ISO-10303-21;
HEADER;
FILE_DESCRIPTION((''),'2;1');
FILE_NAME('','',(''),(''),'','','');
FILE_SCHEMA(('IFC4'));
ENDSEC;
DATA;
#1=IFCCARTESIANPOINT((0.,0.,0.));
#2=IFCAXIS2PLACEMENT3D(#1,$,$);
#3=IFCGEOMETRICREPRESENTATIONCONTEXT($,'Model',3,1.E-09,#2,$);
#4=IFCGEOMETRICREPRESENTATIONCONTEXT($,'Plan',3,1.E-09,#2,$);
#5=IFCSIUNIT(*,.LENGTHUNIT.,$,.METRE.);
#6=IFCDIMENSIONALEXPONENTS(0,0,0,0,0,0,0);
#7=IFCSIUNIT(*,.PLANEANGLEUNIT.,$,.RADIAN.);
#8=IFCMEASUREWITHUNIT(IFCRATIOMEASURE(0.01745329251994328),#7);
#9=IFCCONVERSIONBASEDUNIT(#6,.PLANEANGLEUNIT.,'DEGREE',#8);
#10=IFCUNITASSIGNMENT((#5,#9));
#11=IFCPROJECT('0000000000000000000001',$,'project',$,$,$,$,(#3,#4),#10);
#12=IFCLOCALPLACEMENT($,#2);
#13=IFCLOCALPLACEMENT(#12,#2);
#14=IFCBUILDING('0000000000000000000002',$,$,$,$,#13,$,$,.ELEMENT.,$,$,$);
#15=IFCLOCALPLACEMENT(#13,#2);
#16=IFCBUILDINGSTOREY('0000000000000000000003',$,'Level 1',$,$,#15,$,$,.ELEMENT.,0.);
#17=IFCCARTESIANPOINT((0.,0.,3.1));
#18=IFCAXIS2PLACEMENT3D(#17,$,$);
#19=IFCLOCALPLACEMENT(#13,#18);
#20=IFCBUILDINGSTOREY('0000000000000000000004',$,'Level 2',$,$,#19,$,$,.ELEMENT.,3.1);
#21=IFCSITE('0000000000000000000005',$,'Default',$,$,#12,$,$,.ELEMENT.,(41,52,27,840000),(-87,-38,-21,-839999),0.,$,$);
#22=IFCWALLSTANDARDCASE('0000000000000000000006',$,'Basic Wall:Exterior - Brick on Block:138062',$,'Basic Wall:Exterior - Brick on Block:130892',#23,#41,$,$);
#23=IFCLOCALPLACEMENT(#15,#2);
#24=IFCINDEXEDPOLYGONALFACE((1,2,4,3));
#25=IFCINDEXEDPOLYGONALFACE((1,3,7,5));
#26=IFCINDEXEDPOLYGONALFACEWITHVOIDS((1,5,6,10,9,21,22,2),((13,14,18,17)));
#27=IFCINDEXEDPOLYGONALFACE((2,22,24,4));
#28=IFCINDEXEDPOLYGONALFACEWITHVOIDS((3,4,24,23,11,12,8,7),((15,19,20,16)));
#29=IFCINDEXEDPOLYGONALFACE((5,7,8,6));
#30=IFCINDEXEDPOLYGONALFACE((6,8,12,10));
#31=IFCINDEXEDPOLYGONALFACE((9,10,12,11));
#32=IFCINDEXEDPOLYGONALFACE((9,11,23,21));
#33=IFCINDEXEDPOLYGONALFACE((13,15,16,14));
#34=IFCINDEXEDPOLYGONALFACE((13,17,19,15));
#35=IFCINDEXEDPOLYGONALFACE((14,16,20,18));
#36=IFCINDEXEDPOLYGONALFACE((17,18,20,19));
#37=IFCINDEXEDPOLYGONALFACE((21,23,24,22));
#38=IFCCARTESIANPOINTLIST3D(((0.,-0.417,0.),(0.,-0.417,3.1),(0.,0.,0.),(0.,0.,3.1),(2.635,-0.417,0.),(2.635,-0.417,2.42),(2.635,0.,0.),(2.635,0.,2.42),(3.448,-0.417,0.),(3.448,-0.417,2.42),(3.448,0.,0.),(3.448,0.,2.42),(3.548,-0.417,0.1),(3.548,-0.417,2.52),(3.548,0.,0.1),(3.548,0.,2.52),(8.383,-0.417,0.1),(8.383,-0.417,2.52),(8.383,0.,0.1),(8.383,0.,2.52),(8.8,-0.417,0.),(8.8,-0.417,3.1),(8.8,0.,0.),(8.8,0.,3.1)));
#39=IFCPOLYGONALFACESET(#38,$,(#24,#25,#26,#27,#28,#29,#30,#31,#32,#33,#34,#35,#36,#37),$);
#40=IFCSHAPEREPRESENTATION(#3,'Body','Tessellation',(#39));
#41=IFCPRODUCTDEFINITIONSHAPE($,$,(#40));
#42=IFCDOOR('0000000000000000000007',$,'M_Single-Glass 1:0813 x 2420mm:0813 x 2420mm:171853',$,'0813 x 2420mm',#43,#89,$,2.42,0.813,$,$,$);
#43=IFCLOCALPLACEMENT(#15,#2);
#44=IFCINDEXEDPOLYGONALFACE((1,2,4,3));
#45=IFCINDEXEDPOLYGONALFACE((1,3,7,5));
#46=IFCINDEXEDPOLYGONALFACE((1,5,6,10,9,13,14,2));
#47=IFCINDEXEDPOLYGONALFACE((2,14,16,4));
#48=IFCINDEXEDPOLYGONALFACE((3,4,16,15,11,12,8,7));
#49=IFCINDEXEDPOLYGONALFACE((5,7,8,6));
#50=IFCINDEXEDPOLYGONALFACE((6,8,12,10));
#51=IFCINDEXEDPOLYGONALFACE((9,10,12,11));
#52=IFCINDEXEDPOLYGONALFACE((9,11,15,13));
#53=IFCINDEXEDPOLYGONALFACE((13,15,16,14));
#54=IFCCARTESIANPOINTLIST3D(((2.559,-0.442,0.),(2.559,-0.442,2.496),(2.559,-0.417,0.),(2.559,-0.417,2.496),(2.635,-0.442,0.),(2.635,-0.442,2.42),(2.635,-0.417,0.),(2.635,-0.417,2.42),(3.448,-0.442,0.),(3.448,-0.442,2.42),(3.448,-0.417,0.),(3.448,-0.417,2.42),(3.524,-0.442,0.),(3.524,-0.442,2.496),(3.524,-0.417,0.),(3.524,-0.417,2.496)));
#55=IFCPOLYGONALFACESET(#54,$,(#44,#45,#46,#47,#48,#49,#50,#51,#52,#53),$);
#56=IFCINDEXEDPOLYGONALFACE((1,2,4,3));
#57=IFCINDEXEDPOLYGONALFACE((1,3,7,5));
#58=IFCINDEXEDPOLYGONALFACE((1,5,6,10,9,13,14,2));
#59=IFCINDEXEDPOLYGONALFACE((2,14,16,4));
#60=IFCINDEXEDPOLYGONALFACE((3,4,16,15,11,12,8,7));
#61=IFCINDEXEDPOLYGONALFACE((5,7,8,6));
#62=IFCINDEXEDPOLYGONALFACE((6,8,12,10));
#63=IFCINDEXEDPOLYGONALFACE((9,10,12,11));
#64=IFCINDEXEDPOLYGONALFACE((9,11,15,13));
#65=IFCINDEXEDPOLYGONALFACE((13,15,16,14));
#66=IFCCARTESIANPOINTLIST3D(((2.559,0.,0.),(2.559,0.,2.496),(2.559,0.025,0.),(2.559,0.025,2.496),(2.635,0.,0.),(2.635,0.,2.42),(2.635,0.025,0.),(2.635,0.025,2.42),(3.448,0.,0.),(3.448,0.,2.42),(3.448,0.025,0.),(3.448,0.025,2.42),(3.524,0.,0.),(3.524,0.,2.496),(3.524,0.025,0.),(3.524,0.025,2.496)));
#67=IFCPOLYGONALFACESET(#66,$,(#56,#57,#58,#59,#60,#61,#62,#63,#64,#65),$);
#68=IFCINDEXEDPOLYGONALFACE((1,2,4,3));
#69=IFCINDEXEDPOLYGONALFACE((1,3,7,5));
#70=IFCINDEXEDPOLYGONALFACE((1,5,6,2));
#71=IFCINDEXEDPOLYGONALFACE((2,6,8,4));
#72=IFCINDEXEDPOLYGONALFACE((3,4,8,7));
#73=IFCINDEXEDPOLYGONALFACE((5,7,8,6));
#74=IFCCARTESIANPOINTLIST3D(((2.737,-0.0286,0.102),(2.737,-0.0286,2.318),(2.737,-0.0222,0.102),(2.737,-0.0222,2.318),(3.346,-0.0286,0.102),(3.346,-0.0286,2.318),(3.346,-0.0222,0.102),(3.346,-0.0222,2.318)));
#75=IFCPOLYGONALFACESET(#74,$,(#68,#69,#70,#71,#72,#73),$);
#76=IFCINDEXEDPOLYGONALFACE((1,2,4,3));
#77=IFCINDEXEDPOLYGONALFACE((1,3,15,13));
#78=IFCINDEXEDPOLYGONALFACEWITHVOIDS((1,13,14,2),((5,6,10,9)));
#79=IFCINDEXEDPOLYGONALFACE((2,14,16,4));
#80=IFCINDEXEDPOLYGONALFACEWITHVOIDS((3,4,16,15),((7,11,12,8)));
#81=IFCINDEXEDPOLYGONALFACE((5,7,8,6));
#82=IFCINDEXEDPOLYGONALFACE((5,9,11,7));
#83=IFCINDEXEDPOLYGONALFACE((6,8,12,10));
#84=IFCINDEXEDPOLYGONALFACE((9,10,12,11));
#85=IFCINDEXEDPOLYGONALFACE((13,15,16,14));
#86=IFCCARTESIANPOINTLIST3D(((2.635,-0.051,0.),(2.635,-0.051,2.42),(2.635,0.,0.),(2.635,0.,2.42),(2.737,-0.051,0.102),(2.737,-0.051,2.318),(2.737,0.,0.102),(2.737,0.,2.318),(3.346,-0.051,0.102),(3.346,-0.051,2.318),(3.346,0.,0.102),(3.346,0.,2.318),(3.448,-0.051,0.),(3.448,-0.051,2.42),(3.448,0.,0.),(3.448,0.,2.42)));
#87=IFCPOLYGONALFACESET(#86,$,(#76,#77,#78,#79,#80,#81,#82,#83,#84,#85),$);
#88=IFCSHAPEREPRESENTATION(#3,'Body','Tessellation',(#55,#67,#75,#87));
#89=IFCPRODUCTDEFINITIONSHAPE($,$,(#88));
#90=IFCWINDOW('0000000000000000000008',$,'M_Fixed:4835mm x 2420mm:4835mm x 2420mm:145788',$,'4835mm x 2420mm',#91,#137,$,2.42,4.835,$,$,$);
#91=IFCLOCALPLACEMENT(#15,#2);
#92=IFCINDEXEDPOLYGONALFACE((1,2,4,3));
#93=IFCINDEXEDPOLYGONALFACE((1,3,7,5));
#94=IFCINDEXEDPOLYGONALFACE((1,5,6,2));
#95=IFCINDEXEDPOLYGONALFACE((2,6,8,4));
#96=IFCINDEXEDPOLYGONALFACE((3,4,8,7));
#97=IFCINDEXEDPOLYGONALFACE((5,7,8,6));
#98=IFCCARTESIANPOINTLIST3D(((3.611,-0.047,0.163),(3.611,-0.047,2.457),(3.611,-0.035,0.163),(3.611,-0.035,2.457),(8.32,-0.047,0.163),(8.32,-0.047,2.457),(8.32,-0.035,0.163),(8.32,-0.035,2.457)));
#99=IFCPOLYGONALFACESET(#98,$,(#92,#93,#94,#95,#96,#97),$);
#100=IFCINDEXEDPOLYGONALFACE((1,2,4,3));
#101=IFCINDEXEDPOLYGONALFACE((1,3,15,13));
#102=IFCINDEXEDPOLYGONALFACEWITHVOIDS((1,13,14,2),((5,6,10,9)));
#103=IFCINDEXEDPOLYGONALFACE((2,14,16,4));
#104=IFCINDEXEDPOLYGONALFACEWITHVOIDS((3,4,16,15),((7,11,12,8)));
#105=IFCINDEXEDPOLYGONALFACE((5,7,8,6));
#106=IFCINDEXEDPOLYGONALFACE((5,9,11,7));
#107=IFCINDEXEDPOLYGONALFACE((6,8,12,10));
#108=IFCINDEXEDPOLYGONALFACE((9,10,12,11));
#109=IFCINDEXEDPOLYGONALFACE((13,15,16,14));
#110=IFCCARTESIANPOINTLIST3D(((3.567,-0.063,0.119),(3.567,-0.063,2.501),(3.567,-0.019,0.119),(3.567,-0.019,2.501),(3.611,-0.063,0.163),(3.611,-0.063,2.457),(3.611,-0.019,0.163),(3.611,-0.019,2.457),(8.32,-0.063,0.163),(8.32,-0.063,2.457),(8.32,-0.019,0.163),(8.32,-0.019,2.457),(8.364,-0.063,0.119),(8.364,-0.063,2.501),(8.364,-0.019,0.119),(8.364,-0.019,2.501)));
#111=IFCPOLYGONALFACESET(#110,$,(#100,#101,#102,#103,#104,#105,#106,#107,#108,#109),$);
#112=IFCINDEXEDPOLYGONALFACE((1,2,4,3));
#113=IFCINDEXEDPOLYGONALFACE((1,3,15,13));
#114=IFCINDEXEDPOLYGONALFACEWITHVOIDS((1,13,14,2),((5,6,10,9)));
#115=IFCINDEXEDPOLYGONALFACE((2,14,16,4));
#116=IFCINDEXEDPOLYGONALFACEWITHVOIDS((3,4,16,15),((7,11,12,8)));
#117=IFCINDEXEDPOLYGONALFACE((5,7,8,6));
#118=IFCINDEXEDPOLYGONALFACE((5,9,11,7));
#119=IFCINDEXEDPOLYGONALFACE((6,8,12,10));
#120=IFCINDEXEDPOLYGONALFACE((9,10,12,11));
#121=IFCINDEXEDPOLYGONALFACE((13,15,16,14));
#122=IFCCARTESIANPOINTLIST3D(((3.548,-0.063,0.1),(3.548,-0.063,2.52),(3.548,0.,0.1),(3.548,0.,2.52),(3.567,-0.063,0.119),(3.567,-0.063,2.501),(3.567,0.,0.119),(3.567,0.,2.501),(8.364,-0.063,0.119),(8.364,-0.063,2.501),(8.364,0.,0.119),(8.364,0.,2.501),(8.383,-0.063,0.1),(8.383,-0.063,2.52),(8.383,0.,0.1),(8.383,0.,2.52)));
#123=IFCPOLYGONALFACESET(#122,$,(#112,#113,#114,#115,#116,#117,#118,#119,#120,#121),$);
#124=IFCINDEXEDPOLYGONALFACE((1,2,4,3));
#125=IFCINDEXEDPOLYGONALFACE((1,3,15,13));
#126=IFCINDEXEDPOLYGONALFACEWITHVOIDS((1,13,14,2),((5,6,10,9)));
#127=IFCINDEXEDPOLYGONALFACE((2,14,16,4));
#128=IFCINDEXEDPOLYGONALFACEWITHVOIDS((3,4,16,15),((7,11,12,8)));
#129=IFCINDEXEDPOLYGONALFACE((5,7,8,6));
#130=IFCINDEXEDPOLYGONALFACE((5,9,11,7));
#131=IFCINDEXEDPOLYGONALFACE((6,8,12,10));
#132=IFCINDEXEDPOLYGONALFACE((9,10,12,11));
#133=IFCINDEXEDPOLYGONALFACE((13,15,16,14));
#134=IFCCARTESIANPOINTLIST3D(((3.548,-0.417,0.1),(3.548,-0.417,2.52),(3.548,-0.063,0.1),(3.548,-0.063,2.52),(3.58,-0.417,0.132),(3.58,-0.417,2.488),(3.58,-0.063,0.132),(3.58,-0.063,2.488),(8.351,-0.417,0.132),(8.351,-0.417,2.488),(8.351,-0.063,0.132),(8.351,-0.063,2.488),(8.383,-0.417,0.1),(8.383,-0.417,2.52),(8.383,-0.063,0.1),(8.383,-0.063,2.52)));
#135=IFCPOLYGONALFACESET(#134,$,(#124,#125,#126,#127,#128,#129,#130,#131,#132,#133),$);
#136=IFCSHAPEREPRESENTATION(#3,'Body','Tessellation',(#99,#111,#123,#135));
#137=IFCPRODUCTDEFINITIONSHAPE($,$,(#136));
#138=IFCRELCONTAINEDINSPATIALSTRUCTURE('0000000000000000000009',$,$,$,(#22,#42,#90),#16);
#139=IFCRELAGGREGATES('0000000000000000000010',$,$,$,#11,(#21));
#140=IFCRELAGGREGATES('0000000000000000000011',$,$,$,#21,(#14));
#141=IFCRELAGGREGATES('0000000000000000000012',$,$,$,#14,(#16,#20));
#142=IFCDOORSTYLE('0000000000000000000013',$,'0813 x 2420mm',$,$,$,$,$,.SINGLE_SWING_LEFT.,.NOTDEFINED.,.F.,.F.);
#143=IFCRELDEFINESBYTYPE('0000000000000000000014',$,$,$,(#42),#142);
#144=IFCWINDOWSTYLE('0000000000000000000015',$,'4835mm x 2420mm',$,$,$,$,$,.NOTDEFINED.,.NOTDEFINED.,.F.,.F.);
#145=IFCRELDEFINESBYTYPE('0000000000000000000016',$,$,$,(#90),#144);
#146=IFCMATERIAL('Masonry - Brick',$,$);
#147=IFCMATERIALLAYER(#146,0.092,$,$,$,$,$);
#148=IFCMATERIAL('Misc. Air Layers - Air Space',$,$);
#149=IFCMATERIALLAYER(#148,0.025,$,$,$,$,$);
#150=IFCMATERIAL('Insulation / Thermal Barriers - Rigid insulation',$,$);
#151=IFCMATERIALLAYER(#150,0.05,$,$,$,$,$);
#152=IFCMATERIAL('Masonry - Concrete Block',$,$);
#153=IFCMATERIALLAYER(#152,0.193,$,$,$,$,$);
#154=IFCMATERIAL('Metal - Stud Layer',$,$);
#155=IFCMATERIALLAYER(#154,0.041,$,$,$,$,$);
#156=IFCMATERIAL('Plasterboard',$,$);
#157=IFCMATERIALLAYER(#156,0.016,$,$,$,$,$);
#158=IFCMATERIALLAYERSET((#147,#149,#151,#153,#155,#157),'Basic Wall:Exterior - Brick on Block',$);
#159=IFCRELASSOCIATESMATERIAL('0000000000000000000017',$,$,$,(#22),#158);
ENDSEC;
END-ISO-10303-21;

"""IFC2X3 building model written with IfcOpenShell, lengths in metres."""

from ifc_helpers import new_model, entity, si_unit, converted_unit, frame, frame_2d, origin, origin_2d_with_axis, place, context, project, spatial, polyline, rectangle, outline, extrude, source, transform, mapped, material, layer, layer_set, layer_usage, type_object, type_shapes, element, fill, save


model = new_model("IFC2X3")

# Units and contexts
model_context = context("Model", 3, precision=1e-09, world=origin())
plan_context = context("Plan", 3, precision=1e-09, world=origin())
ifc_project = project(units=[si_unit("LENGTHUNIT", "METRE"), converted_unit("PLANEANGLEUNIT", "DEGREE", entity("IfcRatioMeasure", 0.01745329251994328), si_unit("PLANEANGLEUNIT", "RADIAN"), dimensions=[0, 0, 0, 0, 0, 0, 0])], contexts=[model_context, plan_context])

# Site, building, storey
site_placement = place(None, origin())
site = spatial("IfcSite", under=ifc_project, at=site_placement, Name="Default", CompositionType="ELEMENT", RefLatitude=(41, 52, 27, 840000), RefLongitude=(-87, -38, -21, -839999), RefElevation=0.0)
building_placement = place(site_placement, origin())
building = spatial("IfcBuilding", under=site, at=building_placement, CompositionType="ELEMENT")
storey_1_placement = place(building_placement, origin())
storey_1 = spatial("IfcBuildingStorey", under=building, at=storey_1_placement, Name="Level 1", CompositionType="ELEMENT", Elevation=0.0)

# Shared definitions
ifc_material_1 = material(Name="Masonry - Brick")
ifc_layer_1 = layer(ifc_material_1, 0.092)
ifc_material_2 = material(Name="Misc. Air Layers - Air Space")
ifc_layer_2 = layer(ifc_material_2, 0.025)
ifc_material_3 = material(Name="Insulation / Thermal Barriers - Rigid insulation")
ifc_layer_3 = layer(ifc_material_3, 0.05)
ifc_material_4 = material(Name="Masonry - Concrete Block")
ifc_layer_4 = layer(ifc_material_4, 0.193)
ifc_material_5 = material(Name="Metal - Stud Layer")
ifc_layer_5 = layer(ifc_material_5, 0.041)
ifc_material_6 = material(Name="Plasterboard")
ifc_layer_6 = layer(ifc_material_6, 0.016)
ifc_layer_set_1 = layer_set([ifc_layer_1, ifc_layer_2, ifc_layer_3, ifc_layer_4, ifc_layer_5, ifc_layer_6], Name="Basic Wall:Exterior - Brick on Block")
ifc_layer_usage_1 = layer_usage(ifc_layer_set_1, "AXIS2", "NEGATIVE", 0.2085)

# Wall, openings, door, window
wall_1_placement = place(storey_1_placement, frame((0.0, -0.2085, 0.0)))
wall_1 = element("IfcWallStandardCase", 1, at=wall_1_placement, inside=storey_1, material=ifc_layer_usage_1, Name="Basic Wall:Exterior - Brick on Block:138062", ObjectType="Basic Wall:Exterior - Brick on Block:130892", context=model_context, shape_type="SweptSolid", body=[
    extrude(rectangle(XDim=8.8, YDim=0.417, at=frame_2d((4.4, 0.0), x_axis=(-1.0, 0.0))), origin(), (0.0, 0.0, 1.0), 3.1),
])
opening_1_placement = place(wall_1_placement, frame((3.548, -0.2085, 0.1)))
opening_1 = element("IfcOpeningElement", 2, at=opening_1_placement, cuts=wall_1, ObjectType="Opening", context=model_context, shape_type="SweptSolid", body=[
    extrude(rectangle(XDim=2.42, YDim=4.835, at=frame_2d((1.21, 2.4175), x_axis=(1.0, 0.0))), frame((0.0, 0.0, 0.0), z_axis=(0.0, 1.0, 0.0), x_axis=(0.0, 0.0, 1.0)), (0.0, 0.0, 1.0), 0.417),
])
opening_2_placement = place(wall_1_placement, frame((2.635, -0.2085, 0.0)))
opening_2 = element("IfcOpeningElement", 3, at=opening_2_placement, cuts=wall_1, ObjectType="Opening", context=model_context, shape_type="SweptSolid", body=[
    extrude(rectangle(XDim=0.813, YDim=2.42, at=frame_2d((1.21, 0.4065), x_axis=(0.0, -1.0))), frame((0.0, 0.0, 0.0), z_axis=(0.0, 1.0, 0.0), x_axis=(0.0, 0.0, 1.0)), (0.0, 0.0, 1.0), 0.417),
])
door_style_1 = type_object("IfcDoorStyle", Name="0813 x 2420mm", ConstructionType="NOTDEFINED", OperationType="SINGLE_SWING_LEFT", ParameterTakesPrecedence=False, Sizeable=False)
shared_shape_1 = source(origin(), model_context, "Body", "SweptSolid", [
    extrude(outline(polyline([(-0.4065, -1.191), (-0.4065, 1.229), (-0.4825, 1.229), (-0.4825, -1.267), (0.4825, -1.267), (0.4825, 1.229), (0.4065, 1.229), (0.4065, -1.191), (-0.4065, -1.191)])), frame((0.4065, 0.0, 1.229), z_axis=(0.0, 1.0, 0.0), x_axis=(1.0, 0.0, 0.0)), (0.0, 0.0, -1.0), 0.025),
    extrude(outline(polyline([(-0.4065, -1.191), (-0.4065, 1.229), (-0.4825, 1.229), (-0.4825, -1.267), (0.4825, -1.267), (0.4825, 1.229), (0.4065, 1.229), (0.4065, -1.191), (-0.4065, -1.191)])), frame((0.4065, 0.442, 1.229), z_axis=(0.0, 1.0, 0.0), x_axis=(1.0, 0.0, 0.0)), (0.0, 0.0, -1.0), 0.025),
    extrude(rectangle(XDim=0.609, YDim=0.0064, at=origin_2d_with_axis()), frame((0.4065, 0.3916, 0.102)), (0.0, 0.0, 1.0), 2.216),
    extrude(outline(polyline([(-1.21, -0.4065), (1.21, -0.4065), (1.21, 0.4065), (-1.21, 0.4065), (-1.21, -0.4065)]), holes=[polyline([(-1.108, 0.3045), (1.108, 0.3045), (1.108, -0.3045), (-1.108, -0.3045), (-1.108, 0.3045)])]), frame((0.4065, 0.417, 1.21), z_axis=(0.0, -1.0, 0.0), x_axis=(0.0, 0.0, -1.0)), (0.0, 0.0, 1.0), 0.051),
])
type_shapes(door_style_1, [shared_shape_1])
door_1_placement = place(opening_2_placement, origin())
door_1 = element("IfcDoor", 4, at=door_1_placement, inside=storey_1, type_object=door_style_1, Name="M_Single-Glass 1:0813 x 2420mm:0813 x 2420mm:171853", ObjectType="0813 x 2420mm", OverallHeight=2.42, OverallWidth=0.813, context=model_context, shape_type="MappedRepresentation", body=[
    mapped(shared_shape_1, transform((0.0, 0.0, 0.0), scale=1.0)),
])
fill(opening_2, door_1)
window_style_1 = type_object("IfcWindowStyle", Name="4835mm x 2420mm", ConstructionType="NOTDEFINED", OperationType="NOTDEFINED", ParameterTakesPrecedence=False, Sizeable=False)
shared_shape_2 = source(origin(), model_context, "Body", "SweptSolid", [
    extrude(rectangle(XDim=0.012, YDim=4.709, at=origin_2d_with_axis()), frame((2.4175, 0.376, 0.063), z_axis=(0.0, 0.0, 1.0), x_axis=(0.0, -1.0, 0.0)), (0.0, 0.0, 1.0), 2.294),
    extrude(outline(polyline([(-2.3985, -1.191), (2.3985, -1.191), (2.3985, 1.191), (-2.3985, 1.191), (-2.3985, -1.191)]), holes=[polyline([(-2.3545, -1.147), (-2.3545, 1.147), (2.3545, 1.147), (2.3545, -1.147), (-2.3545, -1.147)])]), frame((2.4175, 0.354, 1.21), z_axis=(0.0, 1.0, 0.0), x_axis=(1.0, 0.0, 0.0)), (0.0, 0.0, 1.0), 0.044),
    extrude(outline(polyline([(-2.4175, -1.21), (2.4175, -1.21), (2.4175, 1.21), (-2.4175, 1.21), (-2.4175, -1.21)]), holes=[polyline([(-2.3985, -1.191), (-2.3985, 1.191), (2.3985, 1.191), (2.3985, -1.191), (-2.3985, -1.191)])]), frame((2.4175, 0.354, 1.21), z_axis=(0.0, 1.0, 0.0), x_axis=(1.0, 0.0, 0.0)), (0.0, 0.0, 1.0), 0.063),
    extrude(outline(polyline([(-2.4175, -1.21), (2.4175, -1.21), (2.4175, 1.21), (-2.4175, 1.21), (-2.4175, -1.21)]), holes=[polyline([(-2.3855, -1.178), (-2.3855, 1.178), (2.3855, 1.178), (2.3855, -1.178), (-2.3855, -1.178)])]), frame((2.4175, 0.0, 1.21), z_axis=(0.0, 1.0, 0.0), x_axis=(1.0, 0.0, 0.0)), (0.0, 0.0, 1.0), 0.354),
])
type_shapes(window_style_1, [shared_shape_2])
window_1_placement = place(opening_1_placement, origin())
window_1 = element("IfcWindow", 5, at=window_1_placement, inside=storey_1, type_object=window_style_1, Name="M_Fixed:4835mm x 2420mm:4835mm x 2420mm:145788", ObjectType="4835mm x 2420mm", OverallHeight=2.42, OverallWidth=4.835, context=model_context, shape_type="MappedRepresentation", body=[
    mapped(shared_shape_2, transform((0.0, 0.0, 0.0), scale=1.0)),
])
fill(opening_1, window_1)

# Shared definitions
storey_2_placement = place(building_placement, frame((0.0, 0.0, 3.1)))
storey_2 = spatial("IfcBuildingStorey", under=building, at=storey_2_placement, Name="Level 2", CompositionType="ELEMENT", Elevation=3.1)

save(model, "model.ifc")
